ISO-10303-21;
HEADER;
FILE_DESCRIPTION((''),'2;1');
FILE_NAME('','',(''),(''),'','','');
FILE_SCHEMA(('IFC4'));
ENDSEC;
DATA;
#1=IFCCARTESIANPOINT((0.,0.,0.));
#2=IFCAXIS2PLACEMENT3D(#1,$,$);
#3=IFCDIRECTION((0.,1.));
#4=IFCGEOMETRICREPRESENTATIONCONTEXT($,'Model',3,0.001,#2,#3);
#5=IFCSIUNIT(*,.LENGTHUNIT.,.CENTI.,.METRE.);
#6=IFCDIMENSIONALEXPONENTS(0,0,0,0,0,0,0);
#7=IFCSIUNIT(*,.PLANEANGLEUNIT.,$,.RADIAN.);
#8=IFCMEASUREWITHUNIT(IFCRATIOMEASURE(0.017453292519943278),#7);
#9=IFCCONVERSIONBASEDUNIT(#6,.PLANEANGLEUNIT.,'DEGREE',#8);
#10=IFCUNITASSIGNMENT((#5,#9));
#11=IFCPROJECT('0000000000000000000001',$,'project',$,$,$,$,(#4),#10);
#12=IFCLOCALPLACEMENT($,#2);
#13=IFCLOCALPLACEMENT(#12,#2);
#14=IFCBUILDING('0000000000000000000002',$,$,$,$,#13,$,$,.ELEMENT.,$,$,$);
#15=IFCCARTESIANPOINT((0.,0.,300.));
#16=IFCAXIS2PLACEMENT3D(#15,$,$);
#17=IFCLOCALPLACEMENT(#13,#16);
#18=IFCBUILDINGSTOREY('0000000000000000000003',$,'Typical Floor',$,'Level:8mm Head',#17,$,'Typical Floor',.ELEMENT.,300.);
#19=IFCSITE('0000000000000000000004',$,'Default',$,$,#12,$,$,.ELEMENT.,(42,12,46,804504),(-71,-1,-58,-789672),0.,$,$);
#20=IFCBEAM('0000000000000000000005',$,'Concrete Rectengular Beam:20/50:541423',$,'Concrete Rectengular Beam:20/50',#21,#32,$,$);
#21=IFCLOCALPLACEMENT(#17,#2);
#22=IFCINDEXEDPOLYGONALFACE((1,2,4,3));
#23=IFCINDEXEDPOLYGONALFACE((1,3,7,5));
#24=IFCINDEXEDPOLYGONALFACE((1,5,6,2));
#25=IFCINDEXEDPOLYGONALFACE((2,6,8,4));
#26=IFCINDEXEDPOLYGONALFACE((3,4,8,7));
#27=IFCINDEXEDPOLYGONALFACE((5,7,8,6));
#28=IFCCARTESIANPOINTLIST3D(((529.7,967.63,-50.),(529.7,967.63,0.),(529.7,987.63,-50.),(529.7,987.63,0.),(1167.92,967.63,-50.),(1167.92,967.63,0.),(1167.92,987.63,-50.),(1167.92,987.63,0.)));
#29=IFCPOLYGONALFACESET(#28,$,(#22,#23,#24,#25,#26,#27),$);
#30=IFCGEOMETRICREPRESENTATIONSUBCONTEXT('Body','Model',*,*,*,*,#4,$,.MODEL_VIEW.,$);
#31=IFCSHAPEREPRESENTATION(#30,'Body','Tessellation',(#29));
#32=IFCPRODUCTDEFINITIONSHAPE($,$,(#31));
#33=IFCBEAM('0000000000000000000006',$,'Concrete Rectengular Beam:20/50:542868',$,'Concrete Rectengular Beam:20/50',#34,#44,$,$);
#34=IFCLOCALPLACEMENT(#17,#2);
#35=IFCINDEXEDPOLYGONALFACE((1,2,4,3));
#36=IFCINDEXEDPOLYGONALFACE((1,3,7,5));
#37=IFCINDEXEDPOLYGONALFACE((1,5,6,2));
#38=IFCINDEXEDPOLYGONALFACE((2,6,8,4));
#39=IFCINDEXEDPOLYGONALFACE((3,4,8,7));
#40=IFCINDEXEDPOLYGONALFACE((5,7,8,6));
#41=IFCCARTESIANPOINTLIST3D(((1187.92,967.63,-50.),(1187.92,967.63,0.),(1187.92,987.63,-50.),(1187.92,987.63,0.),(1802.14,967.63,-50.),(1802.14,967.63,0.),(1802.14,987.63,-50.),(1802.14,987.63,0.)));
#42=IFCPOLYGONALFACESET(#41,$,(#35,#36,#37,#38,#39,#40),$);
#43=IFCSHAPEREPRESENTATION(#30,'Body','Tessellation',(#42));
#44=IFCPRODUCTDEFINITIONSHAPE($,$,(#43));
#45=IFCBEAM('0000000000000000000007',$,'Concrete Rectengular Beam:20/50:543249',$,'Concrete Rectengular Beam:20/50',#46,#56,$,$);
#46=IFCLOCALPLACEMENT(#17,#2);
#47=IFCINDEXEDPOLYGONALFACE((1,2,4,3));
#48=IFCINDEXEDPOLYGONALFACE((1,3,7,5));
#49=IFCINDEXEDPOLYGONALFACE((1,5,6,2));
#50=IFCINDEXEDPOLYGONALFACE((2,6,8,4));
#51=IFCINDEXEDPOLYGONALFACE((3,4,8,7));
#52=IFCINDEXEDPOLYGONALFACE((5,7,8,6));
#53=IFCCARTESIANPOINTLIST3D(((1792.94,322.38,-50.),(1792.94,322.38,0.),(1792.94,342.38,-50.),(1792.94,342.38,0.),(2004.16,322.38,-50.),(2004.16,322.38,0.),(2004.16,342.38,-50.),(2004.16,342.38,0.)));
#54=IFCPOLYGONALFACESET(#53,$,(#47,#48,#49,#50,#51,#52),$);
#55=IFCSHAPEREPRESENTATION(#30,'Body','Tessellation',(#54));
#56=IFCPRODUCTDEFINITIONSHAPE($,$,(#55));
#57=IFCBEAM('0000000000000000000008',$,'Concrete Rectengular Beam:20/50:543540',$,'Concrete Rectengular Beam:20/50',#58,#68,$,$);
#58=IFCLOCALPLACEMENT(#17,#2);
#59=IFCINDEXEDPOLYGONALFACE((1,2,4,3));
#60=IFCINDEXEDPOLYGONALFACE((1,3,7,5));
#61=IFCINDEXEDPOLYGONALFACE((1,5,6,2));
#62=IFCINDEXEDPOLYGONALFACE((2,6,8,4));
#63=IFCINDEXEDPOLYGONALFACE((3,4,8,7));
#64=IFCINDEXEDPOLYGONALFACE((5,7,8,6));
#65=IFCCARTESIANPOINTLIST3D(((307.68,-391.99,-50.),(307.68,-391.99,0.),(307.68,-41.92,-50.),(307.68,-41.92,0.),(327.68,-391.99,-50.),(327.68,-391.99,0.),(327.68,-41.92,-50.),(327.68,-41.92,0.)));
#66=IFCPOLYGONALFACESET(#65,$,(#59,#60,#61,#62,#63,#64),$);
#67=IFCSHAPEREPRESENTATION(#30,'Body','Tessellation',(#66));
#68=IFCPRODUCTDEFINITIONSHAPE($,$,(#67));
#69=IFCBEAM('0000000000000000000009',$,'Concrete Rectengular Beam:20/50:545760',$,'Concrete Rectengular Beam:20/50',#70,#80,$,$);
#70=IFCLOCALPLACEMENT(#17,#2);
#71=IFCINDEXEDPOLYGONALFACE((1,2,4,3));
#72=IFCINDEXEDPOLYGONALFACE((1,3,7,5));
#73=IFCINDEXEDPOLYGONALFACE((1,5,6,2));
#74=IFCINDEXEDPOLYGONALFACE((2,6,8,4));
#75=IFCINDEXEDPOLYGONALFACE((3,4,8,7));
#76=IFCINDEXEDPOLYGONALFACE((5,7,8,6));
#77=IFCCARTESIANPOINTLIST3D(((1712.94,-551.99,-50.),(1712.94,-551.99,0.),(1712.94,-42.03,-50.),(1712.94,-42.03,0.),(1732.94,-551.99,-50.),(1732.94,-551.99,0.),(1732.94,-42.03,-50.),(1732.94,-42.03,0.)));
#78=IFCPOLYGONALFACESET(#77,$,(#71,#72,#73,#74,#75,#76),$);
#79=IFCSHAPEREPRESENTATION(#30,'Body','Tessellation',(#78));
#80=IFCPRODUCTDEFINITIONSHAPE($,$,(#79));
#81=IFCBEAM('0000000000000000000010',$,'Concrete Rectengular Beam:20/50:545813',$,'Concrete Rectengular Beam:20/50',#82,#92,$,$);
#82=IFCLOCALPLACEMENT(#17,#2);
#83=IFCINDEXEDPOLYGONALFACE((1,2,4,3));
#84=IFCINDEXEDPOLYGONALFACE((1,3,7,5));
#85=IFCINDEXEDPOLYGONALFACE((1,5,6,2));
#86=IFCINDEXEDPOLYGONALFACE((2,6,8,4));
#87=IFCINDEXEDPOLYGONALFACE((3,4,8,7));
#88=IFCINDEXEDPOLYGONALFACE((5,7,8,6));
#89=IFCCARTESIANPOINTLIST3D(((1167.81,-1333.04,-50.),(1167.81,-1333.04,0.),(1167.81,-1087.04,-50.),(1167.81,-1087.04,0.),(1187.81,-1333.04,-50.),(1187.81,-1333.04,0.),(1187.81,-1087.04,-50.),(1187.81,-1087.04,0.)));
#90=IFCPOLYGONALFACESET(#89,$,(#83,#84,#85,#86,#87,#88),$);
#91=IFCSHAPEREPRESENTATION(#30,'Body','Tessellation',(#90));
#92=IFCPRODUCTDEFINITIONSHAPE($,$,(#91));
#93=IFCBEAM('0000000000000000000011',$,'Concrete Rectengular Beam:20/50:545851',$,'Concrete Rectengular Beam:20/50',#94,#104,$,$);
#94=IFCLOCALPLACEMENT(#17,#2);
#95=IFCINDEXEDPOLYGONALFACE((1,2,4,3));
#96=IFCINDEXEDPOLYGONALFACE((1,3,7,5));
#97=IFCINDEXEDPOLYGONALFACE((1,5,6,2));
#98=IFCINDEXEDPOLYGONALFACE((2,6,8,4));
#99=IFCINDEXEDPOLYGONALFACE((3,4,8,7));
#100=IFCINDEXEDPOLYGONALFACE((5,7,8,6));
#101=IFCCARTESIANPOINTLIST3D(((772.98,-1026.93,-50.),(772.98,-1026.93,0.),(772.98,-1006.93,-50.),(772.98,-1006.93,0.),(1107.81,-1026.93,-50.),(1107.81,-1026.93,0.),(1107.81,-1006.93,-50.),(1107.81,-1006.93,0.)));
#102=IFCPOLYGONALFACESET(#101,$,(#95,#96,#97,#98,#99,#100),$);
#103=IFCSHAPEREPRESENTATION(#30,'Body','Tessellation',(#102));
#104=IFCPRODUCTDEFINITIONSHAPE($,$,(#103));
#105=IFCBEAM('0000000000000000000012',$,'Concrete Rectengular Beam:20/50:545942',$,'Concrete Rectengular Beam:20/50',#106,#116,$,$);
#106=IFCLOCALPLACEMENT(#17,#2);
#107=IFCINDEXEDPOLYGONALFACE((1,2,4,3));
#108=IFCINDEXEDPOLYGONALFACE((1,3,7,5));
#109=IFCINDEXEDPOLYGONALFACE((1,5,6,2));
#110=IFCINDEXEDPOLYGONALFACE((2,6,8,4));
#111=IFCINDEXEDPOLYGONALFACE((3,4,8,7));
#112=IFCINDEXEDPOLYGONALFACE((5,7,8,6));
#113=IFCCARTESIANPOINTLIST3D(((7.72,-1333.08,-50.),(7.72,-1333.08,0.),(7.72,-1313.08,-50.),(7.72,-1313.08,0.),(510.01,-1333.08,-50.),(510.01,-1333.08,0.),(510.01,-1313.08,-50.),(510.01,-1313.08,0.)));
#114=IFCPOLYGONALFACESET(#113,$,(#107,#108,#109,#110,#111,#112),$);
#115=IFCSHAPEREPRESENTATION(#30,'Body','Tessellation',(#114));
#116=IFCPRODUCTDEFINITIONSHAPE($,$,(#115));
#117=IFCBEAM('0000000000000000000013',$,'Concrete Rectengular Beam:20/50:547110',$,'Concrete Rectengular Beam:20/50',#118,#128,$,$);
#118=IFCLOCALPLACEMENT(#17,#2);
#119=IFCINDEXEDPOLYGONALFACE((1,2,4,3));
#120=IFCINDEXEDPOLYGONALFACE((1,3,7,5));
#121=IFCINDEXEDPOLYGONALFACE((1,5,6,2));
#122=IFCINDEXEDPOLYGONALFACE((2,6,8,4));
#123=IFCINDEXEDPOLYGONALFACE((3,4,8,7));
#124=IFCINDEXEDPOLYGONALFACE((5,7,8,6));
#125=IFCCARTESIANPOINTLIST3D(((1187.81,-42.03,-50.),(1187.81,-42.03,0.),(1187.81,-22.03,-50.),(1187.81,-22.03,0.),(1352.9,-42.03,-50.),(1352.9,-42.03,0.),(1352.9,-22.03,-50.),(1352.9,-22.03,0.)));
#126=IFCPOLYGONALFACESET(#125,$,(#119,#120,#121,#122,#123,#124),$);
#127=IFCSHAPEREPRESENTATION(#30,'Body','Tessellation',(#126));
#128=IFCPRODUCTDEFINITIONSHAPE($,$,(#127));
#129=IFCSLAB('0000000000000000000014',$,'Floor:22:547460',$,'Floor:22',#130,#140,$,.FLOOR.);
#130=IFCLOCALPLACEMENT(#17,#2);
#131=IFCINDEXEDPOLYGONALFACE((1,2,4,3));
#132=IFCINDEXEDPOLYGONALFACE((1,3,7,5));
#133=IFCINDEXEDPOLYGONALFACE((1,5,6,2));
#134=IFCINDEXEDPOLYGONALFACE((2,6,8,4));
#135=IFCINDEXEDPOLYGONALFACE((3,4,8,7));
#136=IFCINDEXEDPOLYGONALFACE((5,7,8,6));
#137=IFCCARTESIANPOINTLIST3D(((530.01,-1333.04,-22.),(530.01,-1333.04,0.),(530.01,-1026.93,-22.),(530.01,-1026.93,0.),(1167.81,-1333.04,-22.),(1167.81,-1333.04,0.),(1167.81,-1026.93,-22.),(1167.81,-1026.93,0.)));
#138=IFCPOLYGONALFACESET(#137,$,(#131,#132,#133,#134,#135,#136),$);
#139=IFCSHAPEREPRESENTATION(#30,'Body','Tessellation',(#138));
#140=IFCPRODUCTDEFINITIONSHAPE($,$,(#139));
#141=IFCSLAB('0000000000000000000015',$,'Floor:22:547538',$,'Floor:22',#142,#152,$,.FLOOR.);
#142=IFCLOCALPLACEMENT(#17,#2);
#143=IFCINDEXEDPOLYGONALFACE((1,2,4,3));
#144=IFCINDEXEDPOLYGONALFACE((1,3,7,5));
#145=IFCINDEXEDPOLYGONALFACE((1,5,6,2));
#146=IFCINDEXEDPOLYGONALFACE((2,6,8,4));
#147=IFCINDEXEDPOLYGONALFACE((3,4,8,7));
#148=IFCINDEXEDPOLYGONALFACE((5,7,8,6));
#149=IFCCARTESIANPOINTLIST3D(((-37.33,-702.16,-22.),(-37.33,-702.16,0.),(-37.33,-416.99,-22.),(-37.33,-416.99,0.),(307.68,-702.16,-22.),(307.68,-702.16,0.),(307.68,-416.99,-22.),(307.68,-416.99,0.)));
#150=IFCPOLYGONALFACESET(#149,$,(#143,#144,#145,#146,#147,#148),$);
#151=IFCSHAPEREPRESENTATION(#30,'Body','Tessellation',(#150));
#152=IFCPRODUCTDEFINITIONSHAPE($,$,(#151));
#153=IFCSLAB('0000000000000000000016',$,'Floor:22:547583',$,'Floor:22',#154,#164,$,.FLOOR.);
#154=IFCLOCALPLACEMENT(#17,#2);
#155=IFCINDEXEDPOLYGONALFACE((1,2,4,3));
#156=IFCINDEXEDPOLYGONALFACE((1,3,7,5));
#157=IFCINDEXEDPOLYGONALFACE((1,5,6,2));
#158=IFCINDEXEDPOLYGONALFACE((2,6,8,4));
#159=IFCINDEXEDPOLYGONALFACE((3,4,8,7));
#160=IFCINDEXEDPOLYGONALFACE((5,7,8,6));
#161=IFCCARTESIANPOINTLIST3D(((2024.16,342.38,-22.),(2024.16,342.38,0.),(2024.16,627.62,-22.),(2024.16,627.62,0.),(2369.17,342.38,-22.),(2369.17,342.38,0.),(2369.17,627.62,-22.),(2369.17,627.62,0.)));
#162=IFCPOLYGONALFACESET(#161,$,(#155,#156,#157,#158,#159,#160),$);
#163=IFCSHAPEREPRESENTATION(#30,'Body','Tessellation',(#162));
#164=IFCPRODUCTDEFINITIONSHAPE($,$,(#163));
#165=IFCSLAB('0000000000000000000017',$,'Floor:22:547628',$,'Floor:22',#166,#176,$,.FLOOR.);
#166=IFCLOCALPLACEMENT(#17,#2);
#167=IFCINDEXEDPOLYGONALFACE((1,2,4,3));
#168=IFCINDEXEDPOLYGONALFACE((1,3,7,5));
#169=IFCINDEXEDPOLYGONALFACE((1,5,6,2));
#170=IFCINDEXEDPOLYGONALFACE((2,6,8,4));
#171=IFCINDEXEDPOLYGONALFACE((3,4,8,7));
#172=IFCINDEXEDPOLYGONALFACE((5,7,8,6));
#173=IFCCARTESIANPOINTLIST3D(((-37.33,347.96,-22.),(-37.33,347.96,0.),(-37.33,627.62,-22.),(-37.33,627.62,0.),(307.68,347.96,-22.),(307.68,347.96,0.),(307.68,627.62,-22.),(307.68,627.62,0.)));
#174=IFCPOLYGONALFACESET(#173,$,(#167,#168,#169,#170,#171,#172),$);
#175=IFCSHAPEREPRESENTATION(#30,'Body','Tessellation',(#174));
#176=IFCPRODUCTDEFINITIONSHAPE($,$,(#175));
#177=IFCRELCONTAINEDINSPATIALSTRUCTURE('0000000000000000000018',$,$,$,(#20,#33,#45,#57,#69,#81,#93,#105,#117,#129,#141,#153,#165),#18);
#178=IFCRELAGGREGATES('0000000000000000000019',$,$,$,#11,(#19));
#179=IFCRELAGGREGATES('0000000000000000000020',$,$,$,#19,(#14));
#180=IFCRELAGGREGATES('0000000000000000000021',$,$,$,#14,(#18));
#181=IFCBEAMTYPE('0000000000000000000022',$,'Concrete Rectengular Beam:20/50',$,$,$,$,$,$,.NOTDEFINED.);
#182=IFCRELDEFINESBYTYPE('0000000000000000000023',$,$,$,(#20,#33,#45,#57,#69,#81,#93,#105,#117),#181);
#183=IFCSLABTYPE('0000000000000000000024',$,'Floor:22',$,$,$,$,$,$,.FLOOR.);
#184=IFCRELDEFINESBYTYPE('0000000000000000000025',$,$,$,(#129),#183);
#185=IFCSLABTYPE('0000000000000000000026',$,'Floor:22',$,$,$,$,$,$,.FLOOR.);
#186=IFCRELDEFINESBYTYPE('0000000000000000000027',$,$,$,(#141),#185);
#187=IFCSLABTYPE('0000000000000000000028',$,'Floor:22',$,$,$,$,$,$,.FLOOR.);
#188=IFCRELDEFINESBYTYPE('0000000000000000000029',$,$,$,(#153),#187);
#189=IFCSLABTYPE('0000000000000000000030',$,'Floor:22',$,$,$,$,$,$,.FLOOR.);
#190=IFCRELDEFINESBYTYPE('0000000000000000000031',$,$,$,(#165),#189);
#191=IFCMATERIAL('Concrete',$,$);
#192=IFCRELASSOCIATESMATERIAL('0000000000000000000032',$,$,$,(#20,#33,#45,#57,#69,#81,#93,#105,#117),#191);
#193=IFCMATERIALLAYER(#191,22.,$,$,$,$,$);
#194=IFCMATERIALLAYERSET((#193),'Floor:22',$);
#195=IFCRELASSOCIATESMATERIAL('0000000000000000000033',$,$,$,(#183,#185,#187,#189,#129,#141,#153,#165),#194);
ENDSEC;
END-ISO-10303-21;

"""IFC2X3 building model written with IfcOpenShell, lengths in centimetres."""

from ifc_helpers import new_model, entity, si_unit, converted_unit, direction, frame, frame_2d, origin, origin_2d_with_axis, place, context, subcontext, project, spatial, rectangle, extrude, material, layer, layer_set, layer_usage, type_object, element, save


model = new_model("IFC2X3")

# Units and contexts
model_context = context("Model", 3, precision=0.001, world=origin(), true_north=direction((0.0, 1.0)))
body_context = subcontext(model_context, "Body", "Model", "MODEL_VIEW")
ifc_project = project(units=[si_unit("LENGTHUNIT", "METRE", prefix="CENTI"), converted_unit("PLANEANGLEUNIT", "DEGREE", entity("IfcRatioMeasure", 0.017453292519943278), si_unit("PLANEANGLEUNIT", "RADIAN"), dimensions=[0, 0, 0, 0, 0, 0, 0])], contexts=[model_context])

# Site, building, storey
site_placement = place(None, origin())
site = spatial("IfcSite", under=ifc_project, at=site_placement, Name="Default", CompositionType="ELEMENT", RefLatitude=(42, 12, 46, 804504), RefLongitude=(-71, -1, -58, -789672), RefElevation=0.0)
building_placement = place(site_placement, origin())
building = spatial("IfcBuilding", under=site, at=building_placement, CompositionType="ELEMENT")
storey_placement = place(building_placement, frame((0.0, 0.0, 300.0)))
storey = spatial("IfcBuildingStorey", under=building, at=storey_placement, Name="Typical Floor", ObjectType="Level:8mm Head", LongName="Typical Floor", CompositionType="ELEMENT", Elevation=300.0)

# Beams
ifc_material = material(Name="Concrete")
beam_type = type_object("IfcBeamType", Name="Concrete Rectengular Beam:20/50", PredefinedType="NOTDEFINED")
beam_1_placement = place(storey_placement, frame((519.7, 977.63, 0.0)))
element("IfcBeam", 1, at=beam_1_placement, inside=storey, type_object=beam_type, material=ifc_material, Name="Concrete Rectengular Beam:20/50:541423", ObjectType="Concrete Rectengular Beam:20/50", context=body_context, shape_type="SweptSolid", body=[
    extrude(rectangle(XDim=50.0, YDim=20.0, at=frame_2d((0.0, 0.0), x_axis=(1.0, 0.0))), frame((10.0, 0.0, -25.0), z_axis=(1.0, 0.0, 0.0), x_axis=(0.0, 0.0, -1.0)), (0.0, 0.0, 1.0), 638.22),
])
beam_2_placement = place(storey_placement, frame((1812.14, 977.63, 0.0), z_axis=(0.0, 0.0, 1.0), x_axis=(-1.0, 0.0, 0.0)))
element("IfcBeam", 2, at=beam_2_placement, inside=storey, type_object=beam_type, material=ifc_material, Name="Concrete Rectengular Beam:20/50:542868", ObjectType="Concrete Rectengular Beam:20/50", context=body_context, shape_type="SweptSolid", body=[
    extrude(rectangle(XDim=50.0, YDim=20.0, at=frame_2d((0.0, 0.0), x_axis=(1.0, 0.0))), frame((10.0, 0.0, -25.0), z_axis=(1.0, 0.0, 0.0), x_axis=(0.0, 0.0, -1.0)), (0.0, 0.0, 1.0), 614.22),
])
beam_3_placement = place(storey_placement, frame((2014.16, 332.38, 0.0), z_axis=(0.0, 0.0, 1.0), x_axis=(-1.0, 0.0, 0.0)))
element("IfcBeam", 3, at=beam_3_placement, inside=storey, type_object=beam_type, material=ifc_material, Name="Concrete Rectengular Beam:20/50:543249", ObjectType="Concrete Rectengular Beam:20/50", context=body_context, shape_type="SweptSolid", body=[
    extrude(rectangle(XDim=50.0, YDim=20.0, at=origin_2d_with_axis()), frame((10.0, 0.0, -25.0), z_axis=(1.0, 0.0, 0.0), x_axis=(0.0, 0.0, -1.0)), (0.0, 0.0, 1.0), 211.22),
])
beam_4_placement = place(storey_placement, frame((317.68, -31.92, 0.0), z_axis=(0.0, 0.0, 1.0), x_axis=(0.0, -1.0, 0.0)))
element("IfcBeam", 4, at=beam_4_placement, inside=storey, type_object=beam_type, material=ifc_material, Name="Concrete Rectengular Beam:20/50:543540", ObjectType="Concrete Rectengular Beam:20/50", context=body_context, shape_type="SweptSolid", body=[
    extrude(rectangle(XDim=50.0, YDim=20.0, at=frame_2d((0.0, 0.0), x_axis=(1.0, 0.0))), frame((10.0, 0.0, -25.0), z_axis=(1.0, 0.0, 0.0), x_axis=(0.0, 0.0, -1.0)), (0.0, 0.0, 1.0), 350.06),
])
beam_5_placement = place(storey_placement, frame((1722.94, -32.03, 0.0), z_axis=(0.0, 0.0, 1.0), x_axis=(0.0, -1.0, 0.0)))
element("IfcBeam", 5, at=beam_5_placement, inside=storey, type_object=beam_type, material=ifc_material, Name="Concrete Rectengular Beam:20/50:545760", ObjectType="Concrete Rectengular Beam:20/50", context=body_context, shape_type="SweptSolid", body=[
    extrude(rectangle(XDim=50.0, YDim=20.0, at=frame_2d((0.0, 0.0), x_axis=(1.0, 0.0))), frame((10.0, 0.0, -25.0), z_axis=(1.0, 0.0, 0.0), x_axis=(0.0, 0.0, -1.0)), (0.0, 0.0, 1.0), 509.96),
])
beam_6_placement = place(storey_placement, frame((1177.81, -1087.04, 0.0), z_axis=(0.0, 0.0, 1.0), x_axis=(0.0, -1.0, 0.0)))
element("IfcBeam", 6, at=beam_6_placement, inside=storey, type_object=beam_type, material=ifc_material, Name="Concrete Rectengular Beam:20/50:545813", ObjectType="Concrete Rectengular Beam:20/50", context=body_context, shape_type="SweptSolid", body=[
    extrude(rectangle(XDim=50.0, YDim=20.0, at=frame_2d((0.0, 0.0), x_axis=(1.0, 0.0))), frame((0.0, 0.0, -25.0), z_axis=(1.0, 0.0, 0.0), x_axis=(0.0, 0.0, -1.0)), (0.0, 0.0, 1.0), 246.0),
])
beam_7_placement = place(storey_placement, frame((1127.81, -1016.93, 0.0), z_axis=(0.0, 0.0, 1.0), x_axis=(-1.0, 0.0, 0.0)))
element("IfcBeam", 7, at=beam_7_placement, inside=storey, type_object=beam_type, material=ifc_material, Name="Concrete Rectengular Beam:20/50:545851", ObjectType="Concrete Rectengular Beam:20/50", context=body_context, shape_type="SweptSolid", body=[
    extrude(rectangle(XDim=50.0, YDim=20.0, at=frame_2d((0.0, 0.0), x_axis=(1.0, 0.0))), frame((20.0, 0.0, -25.0), z_axis=(1.0, 0.0, 0.0), x_axis=(0.0, 0.0, -1.0)), (0.0, 0.0, 1.0), 334.83),
])
beam_8_placement = place(storey_placement, frame((520.01, -1323.08, 0.0), z_axis=(0.0, 0.0, 1.0), x_axis=(-1.0, 0.0, 0.0)))
element("IfcBeam", 8, at=beam_8_placement, inside=storey, type_object=beam_type, material=ifc_material, Name="Concrete Rectengular Beam:20/50:545942", ObjectType="Concrete Rectengular Beam:20/50", context=body_context, shape_type="SweptSolid", body=[
    extrude(rectangle(XDim=50.0, YDim=20.0, at=frame_2d((0.0, 0.0), x_axis=(1.0, 0.0))), frame((10.0, 0.0, -25.0), z_axis=(1.0, 0.0, 0.0), x_axis=(0.0, 0.0, -1.0)), (0.0, 0.0, 1.0), 502.29),
])
beam_9_placement = place(storey_placement, frame((1377.92, -32.03, 0.0), z_axis=(0.0, 0.0, 1.0), x_axis=(-1.0, 0.0, 0.0)))
element("IfcBeam", 9, at=beam_9_placement, inside=storey, type_object=beam_type, material=ifc_material, Name="Concrete Rectengular Beam:20/50:547110", ObjectType="Concrete Rectengular Beam:20/50", context=body_context, shape_type="SweptSolid", body=[
    extrude(rectangle(XDim=50.0, YDim=20.0, at=frame_2d((0.0, 0.0), x_axis=(1.0, 0.0))), frame((25.02, 0.0, -25.0), z_axis=(1.0, 0.0, 0.0), x_axis=(0.0, 0.0, -1.0)), (0.0, 0.0, 1.0), 165.08),
])

# Slabs
ifc_layer = layer(ifc_material, 22.0)
ifc_layer_set = layer_set([ifc_layer], Name="Floor:22")
ifc_layer_usage_1 = layer_usage(ifc_layer_set, "AXIS3", "POSITIVE", 0.0)
slab_type_1 = type_object("IfcSlabType", Name="Floor:22", PredefinedType="FLOOR", material=ifc_layer_set)
slab_1_placement = place(storey_placement, origin())
element("IfcSlab", 10, at=slab_1_placement, inside=storey, type_object=slab_type_1, material=ifc_layer_usage_1, Name="Floor:22:547460", ObjectType="Floor:22", PredefinedType="FLOOR", context=body_context, shape_type="SweptSolid", body=[
    extrude(rectangle(XDim=306.11, YDim=637.8, at=frame_2d((0.0, 0.0), x_axis=(1.0, 0.0))), frame((848.91, -1179.98, 0.0), z_axis=(0.0, 0.0, -1.0), x_axis=(0.0, 1.0, 0.0)), (0.0, 0.0, 1.0), 22.0),
])
ifc_layer_usage_2 = layer_usage(ifc_layer_set, "AXIS3", "POSITIVE", 0.0)
slab_type_2 = type_object("IfcSlabType", Name="Floor:22", PredefinedType="FLOOR", material=ifc_layer_set)
slab_2_placement = place(storey_placement, origin())
element("IfcSlab", 11, at=slab_2_placement, inside=storey, type_object=slab_type_2, material=ifc_layer_usage_2, Name="Floor:22:547538", ObjectType="Floor:22", PredefinedType="FLOOR", context=body_context, shape_type="SweptSolid", body=[
    extrude(rectangle(XDim=285.17, YDim=345.01, at=frame_2d((0.0, 0.0), x_axis=(1.0, 0.0))), frame((135.17, -559.57, 0.0), z_axis=(0.0, 0.0, -1.0), x_axis=(0.0, 1.0, 0.0)), (0.0, 0.0, 1.0), 22.0),
])
ifc_layer_usage_3 = layer_usage(ifc_layer_set, "AXIS3", "POSITIVE", 0.0)
slab_type_3 = type_object("IfcSlabType", Name="Floor:22", PredefinedType="FLOOR", material=ifc_layer_set)
slab_3_placement = place(storey_placement, origin())
element("IfcSlab", 12, at=slab_3_placement, inside=storey, type_object=slab_type_3, material=ifc_layer_usage_3, Name="Floor:22:547583", ObjectType="Floor:22", PredefinedType="FLOOR", context=body_context, shape_type="SweptSolid", body=[
    extrude(rectangle(XDim=285.24, YDim=345.01, at=frame_2d((0.0, 0.0), x_axis=(1.0, 0.0))), frame((2196.66, 485.0, 0.0), z_axis=(0.0, 0.0, -1.0), x_axis=(0.0, 1.0, 0.0)), (0.0, 0.0, 1.0), 22.0),
])
ifc_layer_usage_4 = layer_usage(ifc_layer_set, "AXIS3", "POSITIVE", 0.0)
slab_type_4 = type_object("IfcSlabType", Name="Floor:22", PredefinedType="FLOOR", material=ifc_layer_set)
slab_4_placement = place(storey_placement, origin())
element("IfcSlab", 13, at=slab_4_placement, inside=storey, type_object=slab_type_4, material=ifc_layer_usage_4, Name="Floor:22:547628", ObjectType="Floor:22", PredefinedType="FLOOR", context=body_context, shape_type="SweptSolid", body=[
    extrude(rectangle(XDim=279.67, YDim=345.01, at=frame_2d((0.0, 0.0), x_axis=(1.0, 0.0))), frame((135.17, 487.79, 0.0), z_axis=(0.0, 0.0, -1.0), x_axis=(0.0, 1.0, 0.0)), (0.0, 0.0, 1.0), 22.0),
])

save(model, "model.ifc")
